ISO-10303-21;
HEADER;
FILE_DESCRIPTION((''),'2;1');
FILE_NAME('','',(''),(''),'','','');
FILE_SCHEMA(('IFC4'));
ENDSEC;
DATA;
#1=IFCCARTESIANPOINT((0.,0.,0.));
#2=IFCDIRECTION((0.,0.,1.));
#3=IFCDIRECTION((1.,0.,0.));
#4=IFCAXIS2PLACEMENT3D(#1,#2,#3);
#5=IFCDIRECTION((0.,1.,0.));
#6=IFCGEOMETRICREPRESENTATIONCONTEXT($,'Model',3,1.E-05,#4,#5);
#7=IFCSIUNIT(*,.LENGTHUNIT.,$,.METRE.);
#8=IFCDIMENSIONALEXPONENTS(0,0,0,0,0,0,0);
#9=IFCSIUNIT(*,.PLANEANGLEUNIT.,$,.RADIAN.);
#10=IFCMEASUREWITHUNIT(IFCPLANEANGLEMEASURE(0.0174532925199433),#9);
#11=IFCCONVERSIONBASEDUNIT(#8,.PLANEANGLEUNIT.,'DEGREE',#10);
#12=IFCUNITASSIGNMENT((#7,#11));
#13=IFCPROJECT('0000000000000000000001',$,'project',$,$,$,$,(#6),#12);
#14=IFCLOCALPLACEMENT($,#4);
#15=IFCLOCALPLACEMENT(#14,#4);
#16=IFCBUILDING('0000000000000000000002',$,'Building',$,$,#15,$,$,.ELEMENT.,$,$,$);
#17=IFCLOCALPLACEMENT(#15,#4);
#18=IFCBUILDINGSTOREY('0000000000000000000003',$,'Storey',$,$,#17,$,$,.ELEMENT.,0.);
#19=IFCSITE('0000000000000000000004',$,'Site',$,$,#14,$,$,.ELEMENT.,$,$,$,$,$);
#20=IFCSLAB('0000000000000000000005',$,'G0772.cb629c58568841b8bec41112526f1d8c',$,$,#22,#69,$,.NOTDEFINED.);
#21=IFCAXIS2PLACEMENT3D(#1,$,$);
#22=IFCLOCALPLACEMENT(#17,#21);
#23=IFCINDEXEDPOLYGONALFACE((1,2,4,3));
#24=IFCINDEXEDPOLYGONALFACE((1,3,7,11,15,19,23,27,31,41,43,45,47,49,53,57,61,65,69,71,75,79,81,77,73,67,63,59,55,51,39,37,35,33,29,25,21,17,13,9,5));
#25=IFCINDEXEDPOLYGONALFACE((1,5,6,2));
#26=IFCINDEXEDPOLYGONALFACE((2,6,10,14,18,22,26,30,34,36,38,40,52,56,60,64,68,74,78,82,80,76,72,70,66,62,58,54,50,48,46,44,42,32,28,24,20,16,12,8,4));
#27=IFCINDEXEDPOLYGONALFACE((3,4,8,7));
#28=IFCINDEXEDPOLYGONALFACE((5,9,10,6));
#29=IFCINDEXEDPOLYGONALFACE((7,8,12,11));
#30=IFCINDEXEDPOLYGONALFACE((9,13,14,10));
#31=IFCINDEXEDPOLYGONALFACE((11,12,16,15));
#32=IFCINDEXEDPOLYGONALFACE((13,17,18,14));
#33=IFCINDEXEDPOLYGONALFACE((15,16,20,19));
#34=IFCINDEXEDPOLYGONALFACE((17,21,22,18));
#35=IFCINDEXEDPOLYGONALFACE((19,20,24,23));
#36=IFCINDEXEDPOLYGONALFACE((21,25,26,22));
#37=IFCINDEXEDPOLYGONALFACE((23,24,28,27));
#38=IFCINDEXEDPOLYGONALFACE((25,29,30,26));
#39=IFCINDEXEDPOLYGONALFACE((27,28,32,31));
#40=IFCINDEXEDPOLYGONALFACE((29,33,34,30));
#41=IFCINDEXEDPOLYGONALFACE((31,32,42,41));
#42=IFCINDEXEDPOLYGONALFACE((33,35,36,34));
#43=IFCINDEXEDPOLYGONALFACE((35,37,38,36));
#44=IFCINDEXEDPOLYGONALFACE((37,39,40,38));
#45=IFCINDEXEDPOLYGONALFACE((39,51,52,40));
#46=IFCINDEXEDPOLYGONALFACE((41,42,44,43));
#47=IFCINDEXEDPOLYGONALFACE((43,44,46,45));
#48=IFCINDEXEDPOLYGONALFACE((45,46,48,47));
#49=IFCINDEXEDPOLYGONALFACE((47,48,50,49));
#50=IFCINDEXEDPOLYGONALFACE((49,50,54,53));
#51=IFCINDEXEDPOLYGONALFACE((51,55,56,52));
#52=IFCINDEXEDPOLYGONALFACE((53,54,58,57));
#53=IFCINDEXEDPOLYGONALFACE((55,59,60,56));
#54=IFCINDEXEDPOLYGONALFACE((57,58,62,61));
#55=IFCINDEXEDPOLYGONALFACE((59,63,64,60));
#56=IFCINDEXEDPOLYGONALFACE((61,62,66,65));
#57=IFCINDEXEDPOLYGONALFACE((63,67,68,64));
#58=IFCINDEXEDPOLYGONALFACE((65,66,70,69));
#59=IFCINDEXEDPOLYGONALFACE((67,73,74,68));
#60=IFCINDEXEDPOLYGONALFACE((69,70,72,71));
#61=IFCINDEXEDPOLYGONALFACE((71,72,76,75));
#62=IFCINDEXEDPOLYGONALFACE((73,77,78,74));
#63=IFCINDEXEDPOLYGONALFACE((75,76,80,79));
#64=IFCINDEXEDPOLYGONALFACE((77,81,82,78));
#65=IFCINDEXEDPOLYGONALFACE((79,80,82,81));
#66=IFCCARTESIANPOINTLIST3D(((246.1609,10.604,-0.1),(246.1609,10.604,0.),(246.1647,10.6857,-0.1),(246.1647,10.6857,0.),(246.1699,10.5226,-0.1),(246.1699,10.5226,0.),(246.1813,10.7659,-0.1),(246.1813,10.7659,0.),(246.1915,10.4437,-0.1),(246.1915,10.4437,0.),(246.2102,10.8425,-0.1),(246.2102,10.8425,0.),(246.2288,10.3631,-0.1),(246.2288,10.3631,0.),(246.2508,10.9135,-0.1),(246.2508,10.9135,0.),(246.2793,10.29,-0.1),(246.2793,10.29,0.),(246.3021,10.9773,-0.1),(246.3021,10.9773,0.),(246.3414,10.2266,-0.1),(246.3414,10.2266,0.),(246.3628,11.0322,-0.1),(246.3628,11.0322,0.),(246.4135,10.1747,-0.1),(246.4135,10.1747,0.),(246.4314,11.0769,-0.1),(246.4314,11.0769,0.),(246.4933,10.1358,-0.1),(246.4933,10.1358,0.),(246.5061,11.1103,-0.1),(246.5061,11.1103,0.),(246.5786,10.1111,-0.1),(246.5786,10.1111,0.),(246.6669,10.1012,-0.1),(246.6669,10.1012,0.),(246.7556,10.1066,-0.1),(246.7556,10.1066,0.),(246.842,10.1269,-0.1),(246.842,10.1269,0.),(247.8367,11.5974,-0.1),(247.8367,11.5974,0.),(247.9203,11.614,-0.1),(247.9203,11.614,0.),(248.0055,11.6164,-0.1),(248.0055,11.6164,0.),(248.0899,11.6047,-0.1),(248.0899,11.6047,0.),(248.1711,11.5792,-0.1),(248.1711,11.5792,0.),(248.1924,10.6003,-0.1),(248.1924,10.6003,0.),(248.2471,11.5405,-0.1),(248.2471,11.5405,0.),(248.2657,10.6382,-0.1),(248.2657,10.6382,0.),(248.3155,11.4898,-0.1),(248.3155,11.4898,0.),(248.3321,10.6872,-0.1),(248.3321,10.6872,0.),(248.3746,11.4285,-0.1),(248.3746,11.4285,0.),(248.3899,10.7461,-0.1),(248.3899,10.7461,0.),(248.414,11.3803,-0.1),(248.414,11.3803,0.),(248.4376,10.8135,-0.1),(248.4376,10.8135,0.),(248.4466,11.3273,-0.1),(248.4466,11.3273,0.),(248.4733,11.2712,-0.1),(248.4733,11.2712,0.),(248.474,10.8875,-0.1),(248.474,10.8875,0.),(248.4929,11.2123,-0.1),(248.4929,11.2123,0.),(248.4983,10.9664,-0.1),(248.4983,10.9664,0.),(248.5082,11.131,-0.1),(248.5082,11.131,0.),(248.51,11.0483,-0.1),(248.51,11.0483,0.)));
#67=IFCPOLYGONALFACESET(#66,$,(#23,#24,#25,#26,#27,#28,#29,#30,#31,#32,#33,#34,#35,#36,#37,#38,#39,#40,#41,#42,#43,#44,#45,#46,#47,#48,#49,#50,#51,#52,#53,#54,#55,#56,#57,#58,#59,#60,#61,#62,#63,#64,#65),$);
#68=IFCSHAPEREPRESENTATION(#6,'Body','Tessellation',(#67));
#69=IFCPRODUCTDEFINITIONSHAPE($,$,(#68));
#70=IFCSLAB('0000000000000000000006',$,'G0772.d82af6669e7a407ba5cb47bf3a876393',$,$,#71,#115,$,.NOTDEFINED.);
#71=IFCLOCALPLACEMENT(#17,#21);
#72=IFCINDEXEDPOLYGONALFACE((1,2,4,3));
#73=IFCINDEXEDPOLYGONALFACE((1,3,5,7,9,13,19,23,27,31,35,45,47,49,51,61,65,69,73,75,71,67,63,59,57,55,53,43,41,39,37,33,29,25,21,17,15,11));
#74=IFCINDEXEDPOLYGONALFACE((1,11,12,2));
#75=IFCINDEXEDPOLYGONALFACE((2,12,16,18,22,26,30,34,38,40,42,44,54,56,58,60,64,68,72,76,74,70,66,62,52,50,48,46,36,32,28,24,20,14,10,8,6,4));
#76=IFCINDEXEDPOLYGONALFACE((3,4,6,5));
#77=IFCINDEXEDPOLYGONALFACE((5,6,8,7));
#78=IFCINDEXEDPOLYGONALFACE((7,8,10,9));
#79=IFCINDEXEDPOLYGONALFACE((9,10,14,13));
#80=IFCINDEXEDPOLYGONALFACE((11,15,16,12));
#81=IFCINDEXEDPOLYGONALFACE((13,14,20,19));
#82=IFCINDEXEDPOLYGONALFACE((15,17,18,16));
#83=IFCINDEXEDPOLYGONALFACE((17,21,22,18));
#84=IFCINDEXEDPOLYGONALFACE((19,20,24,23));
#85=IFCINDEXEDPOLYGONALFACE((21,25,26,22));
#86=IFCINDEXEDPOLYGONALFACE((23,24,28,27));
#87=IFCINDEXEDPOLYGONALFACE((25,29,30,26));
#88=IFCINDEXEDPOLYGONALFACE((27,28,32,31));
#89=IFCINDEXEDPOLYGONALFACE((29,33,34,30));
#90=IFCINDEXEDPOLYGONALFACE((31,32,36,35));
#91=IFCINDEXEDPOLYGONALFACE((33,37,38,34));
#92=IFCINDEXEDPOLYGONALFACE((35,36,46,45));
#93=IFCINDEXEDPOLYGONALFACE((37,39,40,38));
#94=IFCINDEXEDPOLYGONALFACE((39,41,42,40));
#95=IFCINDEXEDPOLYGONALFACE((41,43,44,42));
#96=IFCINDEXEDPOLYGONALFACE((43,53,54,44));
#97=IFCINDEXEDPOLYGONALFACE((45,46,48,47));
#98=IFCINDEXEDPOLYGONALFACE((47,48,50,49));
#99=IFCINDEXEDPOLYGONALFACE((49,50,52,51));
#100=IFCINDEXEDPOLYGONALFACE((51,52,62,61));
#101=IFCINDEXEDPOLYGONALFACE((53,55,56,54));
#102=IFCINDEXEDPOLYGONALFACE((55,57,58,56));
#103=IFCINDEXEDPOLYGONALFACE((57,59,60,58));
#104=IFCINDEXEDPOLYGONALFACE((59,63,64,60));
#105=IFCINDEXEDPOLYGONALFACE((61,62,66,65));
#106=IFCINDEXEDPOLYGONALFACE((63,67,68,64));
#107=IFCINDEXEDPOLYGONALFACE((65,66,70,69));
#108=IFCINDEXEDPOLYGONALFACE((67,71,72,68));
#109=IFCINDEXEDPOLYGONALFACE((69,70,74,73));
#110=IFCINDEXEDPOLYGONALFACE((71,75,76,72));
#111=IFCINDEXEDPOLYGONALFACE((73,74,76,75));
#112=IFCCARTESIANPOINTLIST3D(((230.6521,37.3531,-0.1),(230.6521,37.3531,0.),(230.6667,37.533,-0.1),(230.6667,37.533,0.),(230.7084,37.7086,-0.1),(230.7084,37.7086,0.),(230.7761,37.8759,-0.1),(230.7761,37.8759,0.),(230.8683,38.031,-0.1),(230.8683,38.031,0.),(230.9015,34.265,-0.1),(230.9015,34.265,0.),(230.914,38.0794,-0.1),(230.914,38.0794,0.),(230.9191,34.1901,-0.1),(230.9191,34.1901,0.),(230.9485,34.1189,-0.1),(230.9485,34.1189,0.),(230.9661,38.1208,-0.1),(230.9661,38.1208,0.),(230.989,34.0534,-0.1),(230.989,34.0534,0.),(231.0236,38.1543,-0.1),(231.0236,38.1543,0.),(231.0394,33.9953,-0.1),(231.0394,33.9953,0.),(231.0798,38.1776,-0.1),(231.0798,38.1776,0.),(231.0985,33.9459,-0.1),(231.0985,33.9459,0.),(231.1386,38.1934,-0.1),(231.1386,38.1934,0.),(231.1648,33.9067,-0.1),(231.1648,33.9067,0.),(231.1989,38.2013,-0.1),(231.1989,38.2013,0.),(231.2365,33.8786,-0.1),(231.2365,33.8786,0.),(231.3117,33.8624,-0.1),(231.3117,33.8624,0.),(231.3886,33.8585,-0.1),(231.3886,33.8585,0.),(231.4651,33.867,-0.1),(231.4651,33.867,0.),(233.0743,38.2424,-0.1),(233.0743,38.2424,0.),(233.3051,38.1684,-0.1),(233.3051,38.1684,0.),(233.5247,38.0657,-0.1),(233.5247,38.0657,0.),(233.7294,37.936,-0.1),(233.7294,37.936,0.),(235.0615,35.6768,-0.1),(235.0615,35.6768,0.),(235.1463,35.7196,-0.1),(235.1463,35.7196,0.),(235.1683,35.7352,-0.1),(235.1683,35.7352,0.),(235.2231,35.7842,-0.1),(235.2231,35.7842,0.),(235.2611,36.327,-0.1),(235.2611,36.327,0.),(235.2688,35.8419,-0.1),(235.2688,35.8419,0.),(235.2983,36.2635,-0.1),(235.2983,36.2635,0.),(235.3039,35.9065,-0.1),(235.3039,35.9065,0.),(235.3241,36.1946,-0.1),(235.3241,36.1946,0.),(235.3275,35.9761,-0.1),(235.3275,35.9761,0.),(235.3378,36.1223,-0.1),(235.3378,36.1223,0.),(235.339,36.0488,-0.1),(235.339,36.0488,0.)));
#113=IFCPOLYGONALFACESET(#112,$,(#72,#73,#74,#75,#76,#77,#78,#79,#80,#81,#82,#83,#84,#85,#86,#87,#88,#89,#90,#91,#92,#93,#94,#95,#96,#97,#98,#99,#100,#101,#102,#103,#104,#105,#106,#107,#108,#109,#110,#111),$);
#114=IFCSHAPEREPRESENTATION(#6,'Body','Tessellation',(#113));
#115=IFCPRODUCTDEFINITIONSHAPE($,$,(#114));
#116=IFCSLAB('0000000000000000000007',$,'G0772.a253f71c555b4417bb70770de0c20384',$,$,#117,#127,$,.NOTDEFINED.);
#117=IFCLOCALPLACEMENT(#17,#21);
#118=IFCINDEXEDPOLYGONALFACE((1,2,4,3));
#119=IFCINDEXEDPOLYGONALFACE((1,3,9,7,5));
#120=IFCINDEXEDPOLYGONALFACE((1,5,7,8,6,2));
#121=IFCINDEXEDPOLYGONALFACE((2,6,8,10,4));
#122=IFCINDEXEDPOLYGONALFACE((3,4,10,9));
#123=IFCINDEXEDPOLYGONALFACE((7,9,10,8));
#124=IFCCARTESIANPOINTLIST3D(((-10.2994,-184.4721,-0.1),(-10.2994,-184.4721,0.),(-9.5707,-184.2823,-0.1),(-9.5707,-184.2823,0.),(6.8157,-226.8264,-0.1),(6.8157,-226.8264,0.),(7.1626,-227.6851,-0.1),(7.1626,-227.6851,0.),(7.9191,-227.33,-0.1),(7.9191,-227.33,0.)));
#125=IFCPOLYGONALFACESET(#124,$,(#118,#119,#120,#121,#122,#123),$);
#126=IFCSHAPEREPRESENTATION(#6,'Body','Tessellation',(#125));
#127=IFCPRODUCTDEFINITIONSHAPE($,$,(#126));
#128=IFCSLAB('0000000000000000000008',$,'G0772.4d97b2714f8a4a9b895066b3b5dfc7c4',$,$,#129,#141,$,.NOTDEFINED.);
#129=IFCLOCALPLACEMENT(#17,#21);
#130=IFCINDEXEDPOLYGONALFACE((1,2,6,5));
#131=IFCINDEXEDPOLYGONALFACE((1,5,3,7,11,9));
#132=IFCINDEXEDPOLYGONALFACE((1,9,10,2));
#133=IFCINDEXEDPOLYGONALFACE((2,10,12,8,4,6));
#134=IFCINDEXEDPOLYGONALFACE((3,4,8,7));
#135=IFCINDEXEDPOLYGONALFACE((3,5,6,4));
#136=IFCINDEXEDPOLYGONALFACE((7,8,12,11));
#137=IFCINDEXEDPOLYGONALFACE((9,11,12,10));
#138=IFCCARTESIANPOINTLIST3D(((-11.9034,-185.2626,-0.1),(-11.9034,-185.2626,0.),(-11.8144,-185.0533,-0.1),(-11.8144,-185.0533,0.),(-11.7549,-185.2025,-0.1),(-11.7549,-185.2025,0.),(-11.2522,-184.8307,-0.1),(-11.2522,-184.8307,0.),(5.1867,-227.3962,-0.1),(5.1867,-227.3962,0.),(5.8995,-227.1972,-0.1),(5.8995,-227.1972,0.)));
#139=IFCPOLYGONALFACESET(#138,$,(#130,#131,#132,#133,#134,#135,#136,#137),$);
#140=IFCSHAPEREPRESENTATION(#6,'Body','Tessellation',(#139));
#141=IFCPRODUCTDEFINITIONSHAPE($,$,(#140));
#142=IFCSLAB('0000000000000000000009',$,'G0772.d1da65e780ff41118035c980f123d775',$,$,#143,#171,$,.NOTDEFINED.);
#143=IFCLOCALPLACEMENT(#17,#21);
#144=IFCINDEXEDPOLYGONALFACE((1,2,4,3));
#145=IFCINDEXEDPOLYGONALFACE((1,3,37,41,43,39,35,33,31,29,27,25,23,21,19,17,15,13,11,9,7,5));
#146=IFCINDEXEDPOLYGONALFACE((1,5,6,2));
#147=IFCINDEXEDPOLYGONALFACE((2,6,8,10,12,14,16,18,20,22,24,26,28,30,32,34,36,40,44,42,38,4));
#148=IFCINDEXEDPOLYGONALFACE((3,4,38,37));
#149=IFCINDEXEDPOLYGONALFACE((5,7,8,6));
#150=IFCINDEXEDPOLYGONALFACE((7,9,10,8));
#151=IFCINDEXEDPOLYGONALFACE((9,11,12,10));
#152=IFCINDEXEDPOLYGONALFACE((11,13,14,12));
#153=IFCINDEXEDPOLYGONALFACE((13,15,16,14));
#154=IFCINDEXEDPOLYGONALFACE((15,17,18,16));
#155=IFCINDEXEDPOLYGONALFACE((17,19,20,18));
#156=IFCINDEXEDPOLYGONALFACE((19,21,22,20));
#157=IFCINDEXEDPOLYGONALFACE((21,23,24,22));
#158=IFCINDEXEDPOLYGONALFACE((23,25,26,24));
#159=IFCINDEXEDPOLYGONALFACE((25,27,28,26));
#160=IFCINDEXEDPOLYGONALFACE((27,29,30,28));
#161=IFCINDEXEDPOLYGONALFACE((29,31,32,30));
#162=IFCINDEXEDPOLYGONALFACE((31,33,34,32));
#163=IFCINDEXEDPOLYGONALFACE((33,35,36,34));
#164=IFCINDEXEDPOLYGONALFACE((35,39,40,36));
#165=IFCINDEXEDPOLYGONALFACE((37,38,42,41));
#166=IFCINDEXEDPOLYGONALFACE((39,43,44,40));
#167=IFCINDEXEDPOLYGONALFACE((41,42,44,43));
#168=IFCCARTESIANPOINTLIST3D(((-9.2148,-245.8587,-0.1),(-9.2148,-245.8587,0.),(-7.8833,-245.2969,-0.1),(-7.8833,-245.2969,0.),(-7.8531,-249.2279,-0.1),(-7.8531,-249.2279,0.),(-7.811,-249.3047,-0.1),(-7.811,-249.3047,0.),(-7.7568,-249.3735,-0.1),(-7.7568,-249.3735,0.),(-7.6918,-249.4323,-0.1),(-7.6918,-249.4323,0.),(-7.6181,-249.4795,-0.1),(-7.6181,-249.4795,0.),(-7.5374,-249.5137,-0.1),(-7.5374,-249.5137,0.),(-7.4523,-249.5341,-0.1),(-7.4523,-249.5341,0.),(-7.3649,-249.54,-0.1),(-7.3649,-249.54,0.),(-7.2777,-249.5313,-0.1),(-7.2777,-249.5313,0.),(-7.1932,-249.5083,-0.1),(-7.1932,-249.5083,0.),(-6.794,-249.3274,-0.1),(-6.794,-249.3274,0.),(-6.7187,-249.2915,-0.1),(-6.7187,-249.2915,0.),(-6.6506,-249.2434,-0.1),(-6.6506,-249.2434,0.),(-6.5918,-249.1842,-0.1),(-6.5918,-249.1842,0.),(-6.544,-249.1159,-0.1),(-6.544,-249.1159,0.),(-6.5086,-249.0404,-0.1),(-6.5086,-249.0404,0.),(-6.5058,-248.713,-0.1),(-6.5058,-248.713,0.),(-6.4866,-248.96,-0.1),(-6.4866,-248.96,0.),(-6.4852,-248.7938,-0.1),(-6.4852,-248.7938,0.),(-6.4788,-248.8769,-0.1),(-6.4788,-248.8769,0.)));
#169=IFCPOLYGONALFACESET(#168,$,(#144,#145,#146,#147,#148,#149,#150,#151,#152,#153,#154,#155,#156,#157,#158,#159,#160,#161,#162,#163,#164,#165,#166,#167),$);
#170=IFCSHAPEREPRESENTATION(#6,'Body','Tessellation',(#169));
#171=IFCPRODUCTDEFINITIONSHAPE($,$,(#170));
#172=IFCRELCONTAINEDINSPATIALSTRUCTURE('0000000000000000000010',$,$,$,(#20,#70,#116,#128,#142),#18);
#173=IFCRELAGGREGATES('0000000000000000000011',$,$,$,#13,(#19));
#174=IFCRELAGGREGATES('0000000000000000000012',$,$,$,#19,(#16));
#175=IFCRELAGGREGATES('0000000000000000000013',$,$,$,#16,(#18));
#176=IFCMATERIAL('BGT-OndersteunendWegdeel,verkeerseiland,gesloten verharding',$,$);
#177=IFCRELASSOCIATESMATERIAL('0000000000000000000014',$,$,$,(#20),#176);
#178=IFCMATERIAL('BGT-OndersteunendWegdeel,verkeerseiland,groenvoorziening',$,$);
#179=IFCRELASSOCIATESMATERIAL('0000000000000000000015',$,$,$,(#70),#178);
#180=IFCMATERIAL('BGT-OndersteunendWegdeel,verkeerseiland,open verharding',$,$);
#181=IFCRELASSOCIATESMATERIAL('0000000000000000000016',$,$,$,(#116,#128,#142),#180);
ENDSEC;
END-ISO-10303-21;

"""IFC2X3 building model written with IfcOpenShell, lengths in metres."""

from ifc_helpers import new_model, entity, si_unit, converted_unit, direction, frame, origin_with_axes, place, context, project, spatial, polyline, outline, extrude, material, element, save


model = new_model("IFC2X3")

# Units and contexts
model_context = context("Model", 3, precision=1e-05, world=origin_with_axes(), true_north=direction((0.0, 1.0, 0.0)))
ifc_project = project(units=[si_unit("LENGTHUNIT", "METRE"), converted_unit("PLANEANGLEUNIT", "DEGREE", entity("IfcPlaneAngleMeasure", 0.0174532925199433), si_unit("PLANEANGLEUNIT", "RADIAN"), dimensions=[0, 0, 0, 0, 0, 0, 0])], contexts=[model_context])

# Site, building, storey
site_placement = place(None, origin_with_axes())
site = spatial("IfcSite", under=ifc_project, at=site_placement, Name="Site", CompositionType="ELEMENT")
building_placement = place(site_placement, origin_with_axes())
building = spatial("IfcBuilding", under=site, at=building_placement, Name="Building", CompositionType="ELEMENT")
storey_placement = place(building_placement, origin_with_axes())
storey = spatial("IfcBuildingStorey", under=building, at=storey_placement, Name="Storey", CompositionType="ELEMENT", Elevation=0.0)

# Slabs
ifc_material_1 = material(Name="BGT-OndersteunendWegdeel,verkeerseiland,open verharding")
ifc_material_2 = material(Name="BGT-OndersteunendWegdeel,verkeerseiland,gesloten verharding")
ifc_material_3 = material(Name="BGT-OndersteunendWegdeel,verkeerseiland,groenvoorziening")
slab_1_placement = place(storey_placement, frame((0.0, 0.0, -0.1), z_axis=(0.0, 0.0, 1.0), x_axis=(1.0, 0.0, 0.0)))
element("IfcSlab", 1, at=slab_1_placement, inside=storey, material=ifc_material_2, Name="G0772.cb629c58568841b8bec41112526f1d8c", PredefinedType="NOTDEFINED", context=model_context, shape_type="SweptSolid", body=[
    extrude(outline(polyline([(247.9203, 11.614), (248.0055, 11.6164), (248.0899, 11.6047), (248.1711, 11.5792), (248.2471, 11.5405), (248.3155, 11.4898), (248.3746, 11.4285), (248.414, 11.3803), (248.4466, 11.3273), (248.4733, 11.2712), (248.4929, 11.2123), (248.5082, 11.131), (248.51, 11.0483), (248.4983, 10.9664), (248.474, 10.8875), (248.4376, 10.8135), (248.3899, 10.7461), (248.3321, 10.6872), (248.2657, 10.6382), (248.1924, 10.6003), (246.842, 10.1269), (246.7556, 10.1066), (246.6669, 10.1012), (246.5786, 10.1111), (246.4933, 10.1358), (246.4135, 10.1747), (246.3414, 10.2266), (246.2793, 10.29), (246.2288, 10.3631), (246.1915, 10.4437), (246.1699, 10.5226), (246.1609, 10.604), (246.1647, 10.6857), (246.1813, 10.7659), (246.2102, 10.8425), (246.2508, 10.9135), (246.3021, 10.9773), (246.3628, 11.0322), (246.4314, 11.0769), (246.5061, 11.1103), (247.8367, 11.5974), (247.9203, 11.614)])), origin_with_axes(), (0.0, 0.0, 1.0), 0.1),
])
slab_2_placement = place(storey_placement, frame((0.0, 0.0, -0.1), z_axis=(0.0, 0.0, 1.0), x_axis=(1.0, 0.0, 0.0)))
element("IfcSlab", 2, at=slab_2_placement, inside=storey, material=ifc_material_3, Name="G0772.d82af6669e7a407ba5cb47bf3a876393", PredefinedType="NOTDEFINED", context=model_context, shape_type="SweptSolid", body=[
    extrude(outline(polyline([(231.0798, 38.1776), (231.1386, 38.1934), (231.1989, 38.2013), (233.0743, 38.2424), (233.3051, 38.1684), (233.5247, 38.0657), (233.7294, 37.936), (235.2611, 36.327), (235.2983, 36.2635), (235.3241, 36.1946), (235.3378, 36.1223), (235.339, 36.0488), (235.3275, 35.9761), (235.3039, 35.9065), (235.2688, 35.8419), (235.2231, 35.7842), (235.1683, 35.7352), (235.1463, 35.7196), (235.0615, 35.6768), (231.4651, 33.867), (231.3886, 33.8585), (231.3117, 33.8624), (231.2365, 33.8786), (231.1648, 33.9067), (231.0985, 33.9459), (231.0394, 33.9953), (230.989, 34.0534), (230.9485, 34.1189), (230.9191, 34.1901), (230.9015, 34.265), (230.6521, 37.3531), (230.6667, 37.533), (230.7084, 37.7086), (230.7761, 37.8759), (230.8683, 38.031), (230.914, 38.0794), (230.9661, 38.1208), (231.0236, 38.1543), (231.0798, 38.1776)])), origin_with_axes(), (0.0, 0.0, 1.0), 0.1),
])
slab_3_placement = place(storey_placement, frame((0.0, 0.0, -0.1), z_axis=(0.0, 0.0, 1.0), x_axis=(1.0, 0.0, 0.0)))
element("IfcSlab", 3, at=slab_3_placement, inside=storey, material=ifc_material_1, Name="G0772.a253f71c555b4417bb70770de0c20384", PredefinedType="NOTDEFINED", context=model_context, shape_type="SweptSolid", body=[
    extrude(outline(polyline([(7.1626, -227.6851), (6.8157, -226.8264), (-10.2994, -184.4721), (-9.5707, -184.2823), (7.9191, -227.33), (7.1626, -227.6851)])), origin_with_axes(), (0.0, 0.0, 1.0), 0.1),
])
slab_4_placement = place(storey_placement, frame((0.0, 0.0, -0.1), z_axis=(0.0, 0.0, 1.0), x_axis=(1.0, 0.0, 0.0)))
element("IfcSlab", 4, at=slab_4_placement, inside=storey, material=ifc_material_1, Name="G0772.4d97b2714f8a4a9b895066b3b5dfc7c4", PredefinedType="NOTDEFINED", context=model_context, shape_type="SweptSolid", body=[
    extrude(outline(polyline([(-11.9034, -185.2626), (-11.7549, -185.2025), (-11.8144, -185.0533), (-11.2522, -184.8307), (5.8995, -227.1972), (5.1867, -227.3962), (-11.9034, -185.2626)])), origin_with_axes(), (0.0, 0.0, 1.0), 0.1),
])
slab_5_placement = place(storey_placement, frame((0.0, 0.0, -0.1), z_axis=(0.0, 0.0, 1.0), x_axis=(1.0, 0.0, 0.0)))
element("IfcSlab", 5, at=slab_5_placement, inside=storey, material=ifc_material_1, Name="G0772.d1da65e780ff41118035c980f123d775", PredefinedType="NOTDEFINED", context=model_context, shape_type="SweptSolid", body=[
    extrude(outline(polyline([(-7.1932, -249.5083), (-7.2777, -249.5313), (-7.3649, -249.54), (-7.4523, -249.5341), (-7.5374, -249.5137), (-7.6181, -249.4795), (-7.6918, -249.4323), (-7.7568, -249.3735), (-7.811, -249.3047), (-7.8531, -249.2279), (-9.2148, -245.8587), (-7.8833, -245.2969), (-6.5058, -248.713), (-6.4852, -248.7938), (-6.4788, -248.8769), (-6.4866, -248.96), (-6.5086, -249.0404), (-6.544, -249.1159), (-6.5918, -249.1842), (-6.6506, -249.2434), (-6.7187, -249.2915), (-6.794, -249.3274), (-7.1932, -249.5083)])), origin_with_axes(), (0.0, 0.0, 1.0), 0.1),
])

save(model, "model.ifc")
